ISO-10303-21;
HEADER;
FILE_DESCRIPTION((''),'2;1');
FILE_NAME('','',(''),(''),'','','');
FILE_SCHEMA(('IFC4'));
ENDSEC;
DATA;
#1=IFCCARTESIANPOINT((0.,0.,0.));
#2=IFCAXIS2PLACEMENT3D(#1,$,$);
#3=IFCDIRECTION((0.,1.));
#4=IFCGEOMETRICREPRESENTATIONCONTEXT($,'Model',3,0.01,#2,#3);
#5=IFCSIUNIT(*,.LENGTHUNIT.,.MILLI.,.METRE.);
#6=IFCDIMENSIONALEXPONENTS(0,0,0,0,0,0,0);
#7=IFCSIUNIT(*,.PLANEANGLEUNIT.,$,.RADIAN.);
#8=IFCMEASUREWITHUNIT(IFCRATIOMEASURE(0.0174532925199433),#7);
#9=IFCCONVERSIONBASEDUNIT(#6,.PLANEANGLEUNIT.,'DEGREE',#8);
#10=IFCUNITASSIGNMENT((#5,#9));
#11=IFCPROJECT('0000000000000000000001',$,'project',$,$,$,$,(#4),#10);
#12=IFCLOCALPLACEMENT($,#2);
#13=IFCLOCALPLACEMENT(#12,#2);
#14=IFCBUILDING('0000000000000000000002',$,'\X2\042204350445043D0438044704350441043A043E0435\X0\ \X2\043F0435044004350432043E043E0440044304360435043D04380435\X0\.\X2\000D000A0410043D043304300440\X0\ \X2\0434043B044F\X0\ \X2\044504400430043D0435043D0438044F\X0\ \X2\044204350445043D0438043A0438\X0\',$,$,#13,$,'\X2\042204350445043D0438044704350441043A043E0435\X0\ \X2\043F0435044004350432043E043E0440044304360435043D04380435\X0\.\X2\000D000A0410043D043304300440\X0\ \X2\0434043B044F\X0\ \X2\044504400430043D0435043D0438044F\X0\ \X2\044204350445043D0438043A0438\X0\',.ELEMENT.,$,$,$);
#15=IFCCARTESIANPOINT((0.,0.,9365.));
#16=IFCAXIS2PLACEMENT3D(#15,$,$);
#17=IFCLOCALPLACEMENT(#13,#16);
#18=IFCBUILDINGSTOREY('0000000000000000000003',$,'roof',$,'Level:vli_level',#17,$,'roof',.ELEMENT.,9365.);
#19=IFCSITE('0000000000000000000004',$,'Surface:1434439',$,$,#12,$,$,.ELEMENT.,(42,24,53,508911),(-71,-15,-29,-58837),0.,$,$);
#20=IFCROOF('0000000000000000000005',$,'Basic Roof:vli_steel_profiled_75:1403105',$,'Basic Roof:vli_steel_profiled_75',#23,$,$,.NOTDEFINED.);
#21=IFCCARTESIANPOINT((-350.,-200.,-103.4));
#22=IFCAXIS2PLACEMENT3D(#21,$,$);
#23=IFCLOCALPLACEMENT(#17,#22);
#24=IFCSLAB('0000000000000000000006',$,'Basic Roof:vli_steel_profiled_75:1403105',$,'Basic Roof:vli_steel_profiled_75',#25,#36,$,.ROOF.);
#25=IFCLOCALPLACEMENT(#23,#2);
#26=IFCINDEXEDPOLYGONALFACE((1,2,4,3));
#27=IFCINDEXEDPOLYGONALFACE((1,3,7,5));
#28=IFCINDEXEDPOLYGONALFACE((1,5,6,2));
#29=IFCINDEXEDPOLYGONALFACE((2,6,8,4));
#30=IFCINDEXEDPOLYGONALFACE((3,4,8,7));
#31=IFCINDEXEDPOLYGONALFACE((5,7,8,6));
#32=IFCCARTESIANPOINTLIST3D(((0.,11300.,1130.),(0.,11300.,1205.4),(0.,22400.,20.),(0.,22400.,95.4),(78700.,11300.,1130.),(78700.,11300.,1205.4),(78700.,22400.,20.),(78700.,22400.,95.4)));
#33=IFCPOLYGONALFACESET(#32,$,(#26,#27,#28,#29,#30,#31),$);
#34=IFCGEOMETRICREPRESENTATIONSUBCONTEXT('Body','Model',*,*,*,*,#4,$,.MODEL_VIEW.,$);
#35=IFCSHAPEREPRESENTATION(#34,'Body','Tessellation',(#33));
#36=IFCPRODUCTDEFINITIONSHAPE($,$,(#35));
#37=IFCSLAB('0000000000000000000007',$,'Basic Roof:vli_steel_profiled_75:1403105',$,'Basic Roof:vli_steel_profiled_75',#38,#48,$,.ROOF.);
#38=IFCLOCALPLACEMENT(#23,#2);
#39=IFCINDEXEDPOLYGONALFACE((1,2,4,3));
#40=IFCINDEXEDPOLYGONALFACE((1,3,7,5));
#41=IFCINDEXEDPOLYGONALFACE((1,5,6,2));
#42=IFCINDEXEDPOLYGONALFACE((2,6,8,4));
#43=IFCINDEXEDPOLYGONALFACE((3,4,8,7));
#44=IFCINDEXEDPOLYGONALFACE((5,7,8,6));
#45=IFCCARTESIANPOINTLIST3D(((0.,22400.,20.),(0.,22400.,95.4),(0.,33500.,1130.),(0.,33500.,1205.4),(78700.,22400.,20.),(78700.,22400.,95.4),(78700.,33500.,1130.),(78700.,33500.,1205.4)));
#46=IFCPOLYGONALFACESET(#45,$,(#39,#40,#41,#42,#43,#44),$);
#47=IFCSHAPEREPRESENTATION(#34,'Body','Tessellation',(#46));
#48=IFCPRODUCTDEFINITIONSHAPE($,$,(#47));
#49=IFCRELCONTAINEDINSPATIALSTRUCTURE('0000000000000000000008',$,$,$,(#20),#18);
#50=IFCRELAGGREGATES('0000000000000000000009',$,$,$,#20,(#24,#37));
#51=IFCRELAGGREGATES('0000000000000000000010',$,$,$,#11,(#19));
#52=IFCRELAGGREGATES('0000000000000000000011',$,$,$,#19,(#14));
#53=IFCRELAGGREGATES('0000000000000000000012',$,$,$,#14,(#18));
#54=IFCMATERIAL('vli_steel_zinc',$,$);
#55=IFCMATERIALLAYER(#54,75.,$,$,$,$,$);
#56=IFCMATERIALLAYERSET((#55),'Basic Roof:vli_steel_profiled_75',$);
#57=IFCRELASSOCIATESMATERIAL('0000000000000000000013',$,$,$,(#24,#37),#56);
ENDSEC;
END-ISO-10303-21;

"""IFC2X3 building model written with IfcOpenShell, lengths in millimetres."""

from ifc_helpers import new_model, entity, si_unit, converted_unit, direction, frame, frame_2d, origin, place, context, subcontext, project, spatial, rectangle, extrude, material, layer, layer_set, element, aggregate, save


model = new_model("IFC2X3")

# Units and contexts
model_context = context("Model", 3, precision=0.01, world=origin(), true_north=direction((0.0, 1.0)))
body_context = subcontext(model_context, "Body", "Model", "MODEL_VIEW")
ifc_project = project(units=[si_unit("LENGTHUNIT", "METRE", prefix="MILLI"), converted_unit("PLANEANGLEUNIT", "DEGREE", entity("IfcRatioMeasure", 0.0174532925199433), si_unit("PLANEANGLEUNIT", "RADIAN"), dimensions=[0, 0, 0, 0, 0, 0, 0])], contexts=[model_context])

# Site, building, storey
site_placement = place(None, origin())
site = spatial("IfcSite", under=ifc_project, at=site_placement, Name="Surface:1434439", CompositionType="ELEMENT", RefLatitude=(42, 24, 53, 508911), RefLongitude=(-71, -15, -29, -58837), RefElevation=0.0)
building_placement = place(site_placement, origin())
building = spatial("IfcBuilding", under=site, at=building_placement, Name="Техническое перевооружение.\r\nАнгар для хранения техники", LongName="Техническое перевооружение.\r\nАнгар для хранения техники", CompositionType="ELEMENT")
storey_placement = place(building_placement, frame((0.0, 0.0, 9365.0)))
storey = spatial("IfcBuildingStorey", under=building, at=storey_placement, Name="roof", ObjectType="Level:vli_level", LongName="roof", CompositionType="ELEMENT", Elevation=9365.0)

# Roof, slabs
roof_placement = place(storey_placement, frame((-350.0, -200.0, -103.4)))
roof = element("IfcRoof", 1, at=roof_placement, inside=storey, Name="Basic Roof:vli_steel_profiled_75:1403105", ObjectType="Basic Roof:vli_steel_profiled_75", ShapeType="NOTDEFINED")
ifc_material_1 = material(Name="vli_steel_zinc")
ifc_layer = layer(ifc_material_1, 75.0)
ifc_layer_set = layer_set([ifc_layer], Name="Basic Roof:vli_steel_profiled_75")
slab_1_placement = place(roof_placement, origin())
slab_1 = element("IfcSlab", 2, at=slab_1_placement, material=ifc_layer_set, Name="Basic Roof:vli_steel_profiled_75:1403105", ObjectType="Basic Roof:vli_steel_profiled_75", PredefinedType="ROOF", context=body_context, shape_type="SweptSolid", body=[
    extrude(rectangle(XDim=78700.0, YDim=11155.4, at=frame_2d((0.0, 0.0), x_axis=(1.0, 0.0))), frame((39350.0, 16850.0, 575.0), z_axis=(0.0, 0.099504, 0.995037), x_axis=(1.0, 0.0, 0.0)), (0.0, -0.099504, 0.995037), 75.4),
])
slab_2_placement = place(roof_placement, origin())
slab_2 = element("IfcSlab", 3, at=slab_2_placement, material=ifc_layer_set, Name="Basic Roof:vli_steel_profiled_75:1403105", ObjectType="Basic Roof:vli_steel_profiled_75", PredefinedType="ROOF", context=body_context, shape_type="SweptSolid", body=[
    extrude(rectangle(XDim=78700.0, YDim=11155.4, at=frame_2d((0.0, 0.0), x_axis=(1.0, 0.0))), frame((39350.0, 27950.0, 575.0), z_axis=(0.0, -0.099504, 0.995037), x_axis=(1.0, 0.0, 0.0)), (0.0, 0.099504, 0.995037), 75.4),
])
aggregate(roof, [slab_1, slab_2])

save(model, "model.ifc")
